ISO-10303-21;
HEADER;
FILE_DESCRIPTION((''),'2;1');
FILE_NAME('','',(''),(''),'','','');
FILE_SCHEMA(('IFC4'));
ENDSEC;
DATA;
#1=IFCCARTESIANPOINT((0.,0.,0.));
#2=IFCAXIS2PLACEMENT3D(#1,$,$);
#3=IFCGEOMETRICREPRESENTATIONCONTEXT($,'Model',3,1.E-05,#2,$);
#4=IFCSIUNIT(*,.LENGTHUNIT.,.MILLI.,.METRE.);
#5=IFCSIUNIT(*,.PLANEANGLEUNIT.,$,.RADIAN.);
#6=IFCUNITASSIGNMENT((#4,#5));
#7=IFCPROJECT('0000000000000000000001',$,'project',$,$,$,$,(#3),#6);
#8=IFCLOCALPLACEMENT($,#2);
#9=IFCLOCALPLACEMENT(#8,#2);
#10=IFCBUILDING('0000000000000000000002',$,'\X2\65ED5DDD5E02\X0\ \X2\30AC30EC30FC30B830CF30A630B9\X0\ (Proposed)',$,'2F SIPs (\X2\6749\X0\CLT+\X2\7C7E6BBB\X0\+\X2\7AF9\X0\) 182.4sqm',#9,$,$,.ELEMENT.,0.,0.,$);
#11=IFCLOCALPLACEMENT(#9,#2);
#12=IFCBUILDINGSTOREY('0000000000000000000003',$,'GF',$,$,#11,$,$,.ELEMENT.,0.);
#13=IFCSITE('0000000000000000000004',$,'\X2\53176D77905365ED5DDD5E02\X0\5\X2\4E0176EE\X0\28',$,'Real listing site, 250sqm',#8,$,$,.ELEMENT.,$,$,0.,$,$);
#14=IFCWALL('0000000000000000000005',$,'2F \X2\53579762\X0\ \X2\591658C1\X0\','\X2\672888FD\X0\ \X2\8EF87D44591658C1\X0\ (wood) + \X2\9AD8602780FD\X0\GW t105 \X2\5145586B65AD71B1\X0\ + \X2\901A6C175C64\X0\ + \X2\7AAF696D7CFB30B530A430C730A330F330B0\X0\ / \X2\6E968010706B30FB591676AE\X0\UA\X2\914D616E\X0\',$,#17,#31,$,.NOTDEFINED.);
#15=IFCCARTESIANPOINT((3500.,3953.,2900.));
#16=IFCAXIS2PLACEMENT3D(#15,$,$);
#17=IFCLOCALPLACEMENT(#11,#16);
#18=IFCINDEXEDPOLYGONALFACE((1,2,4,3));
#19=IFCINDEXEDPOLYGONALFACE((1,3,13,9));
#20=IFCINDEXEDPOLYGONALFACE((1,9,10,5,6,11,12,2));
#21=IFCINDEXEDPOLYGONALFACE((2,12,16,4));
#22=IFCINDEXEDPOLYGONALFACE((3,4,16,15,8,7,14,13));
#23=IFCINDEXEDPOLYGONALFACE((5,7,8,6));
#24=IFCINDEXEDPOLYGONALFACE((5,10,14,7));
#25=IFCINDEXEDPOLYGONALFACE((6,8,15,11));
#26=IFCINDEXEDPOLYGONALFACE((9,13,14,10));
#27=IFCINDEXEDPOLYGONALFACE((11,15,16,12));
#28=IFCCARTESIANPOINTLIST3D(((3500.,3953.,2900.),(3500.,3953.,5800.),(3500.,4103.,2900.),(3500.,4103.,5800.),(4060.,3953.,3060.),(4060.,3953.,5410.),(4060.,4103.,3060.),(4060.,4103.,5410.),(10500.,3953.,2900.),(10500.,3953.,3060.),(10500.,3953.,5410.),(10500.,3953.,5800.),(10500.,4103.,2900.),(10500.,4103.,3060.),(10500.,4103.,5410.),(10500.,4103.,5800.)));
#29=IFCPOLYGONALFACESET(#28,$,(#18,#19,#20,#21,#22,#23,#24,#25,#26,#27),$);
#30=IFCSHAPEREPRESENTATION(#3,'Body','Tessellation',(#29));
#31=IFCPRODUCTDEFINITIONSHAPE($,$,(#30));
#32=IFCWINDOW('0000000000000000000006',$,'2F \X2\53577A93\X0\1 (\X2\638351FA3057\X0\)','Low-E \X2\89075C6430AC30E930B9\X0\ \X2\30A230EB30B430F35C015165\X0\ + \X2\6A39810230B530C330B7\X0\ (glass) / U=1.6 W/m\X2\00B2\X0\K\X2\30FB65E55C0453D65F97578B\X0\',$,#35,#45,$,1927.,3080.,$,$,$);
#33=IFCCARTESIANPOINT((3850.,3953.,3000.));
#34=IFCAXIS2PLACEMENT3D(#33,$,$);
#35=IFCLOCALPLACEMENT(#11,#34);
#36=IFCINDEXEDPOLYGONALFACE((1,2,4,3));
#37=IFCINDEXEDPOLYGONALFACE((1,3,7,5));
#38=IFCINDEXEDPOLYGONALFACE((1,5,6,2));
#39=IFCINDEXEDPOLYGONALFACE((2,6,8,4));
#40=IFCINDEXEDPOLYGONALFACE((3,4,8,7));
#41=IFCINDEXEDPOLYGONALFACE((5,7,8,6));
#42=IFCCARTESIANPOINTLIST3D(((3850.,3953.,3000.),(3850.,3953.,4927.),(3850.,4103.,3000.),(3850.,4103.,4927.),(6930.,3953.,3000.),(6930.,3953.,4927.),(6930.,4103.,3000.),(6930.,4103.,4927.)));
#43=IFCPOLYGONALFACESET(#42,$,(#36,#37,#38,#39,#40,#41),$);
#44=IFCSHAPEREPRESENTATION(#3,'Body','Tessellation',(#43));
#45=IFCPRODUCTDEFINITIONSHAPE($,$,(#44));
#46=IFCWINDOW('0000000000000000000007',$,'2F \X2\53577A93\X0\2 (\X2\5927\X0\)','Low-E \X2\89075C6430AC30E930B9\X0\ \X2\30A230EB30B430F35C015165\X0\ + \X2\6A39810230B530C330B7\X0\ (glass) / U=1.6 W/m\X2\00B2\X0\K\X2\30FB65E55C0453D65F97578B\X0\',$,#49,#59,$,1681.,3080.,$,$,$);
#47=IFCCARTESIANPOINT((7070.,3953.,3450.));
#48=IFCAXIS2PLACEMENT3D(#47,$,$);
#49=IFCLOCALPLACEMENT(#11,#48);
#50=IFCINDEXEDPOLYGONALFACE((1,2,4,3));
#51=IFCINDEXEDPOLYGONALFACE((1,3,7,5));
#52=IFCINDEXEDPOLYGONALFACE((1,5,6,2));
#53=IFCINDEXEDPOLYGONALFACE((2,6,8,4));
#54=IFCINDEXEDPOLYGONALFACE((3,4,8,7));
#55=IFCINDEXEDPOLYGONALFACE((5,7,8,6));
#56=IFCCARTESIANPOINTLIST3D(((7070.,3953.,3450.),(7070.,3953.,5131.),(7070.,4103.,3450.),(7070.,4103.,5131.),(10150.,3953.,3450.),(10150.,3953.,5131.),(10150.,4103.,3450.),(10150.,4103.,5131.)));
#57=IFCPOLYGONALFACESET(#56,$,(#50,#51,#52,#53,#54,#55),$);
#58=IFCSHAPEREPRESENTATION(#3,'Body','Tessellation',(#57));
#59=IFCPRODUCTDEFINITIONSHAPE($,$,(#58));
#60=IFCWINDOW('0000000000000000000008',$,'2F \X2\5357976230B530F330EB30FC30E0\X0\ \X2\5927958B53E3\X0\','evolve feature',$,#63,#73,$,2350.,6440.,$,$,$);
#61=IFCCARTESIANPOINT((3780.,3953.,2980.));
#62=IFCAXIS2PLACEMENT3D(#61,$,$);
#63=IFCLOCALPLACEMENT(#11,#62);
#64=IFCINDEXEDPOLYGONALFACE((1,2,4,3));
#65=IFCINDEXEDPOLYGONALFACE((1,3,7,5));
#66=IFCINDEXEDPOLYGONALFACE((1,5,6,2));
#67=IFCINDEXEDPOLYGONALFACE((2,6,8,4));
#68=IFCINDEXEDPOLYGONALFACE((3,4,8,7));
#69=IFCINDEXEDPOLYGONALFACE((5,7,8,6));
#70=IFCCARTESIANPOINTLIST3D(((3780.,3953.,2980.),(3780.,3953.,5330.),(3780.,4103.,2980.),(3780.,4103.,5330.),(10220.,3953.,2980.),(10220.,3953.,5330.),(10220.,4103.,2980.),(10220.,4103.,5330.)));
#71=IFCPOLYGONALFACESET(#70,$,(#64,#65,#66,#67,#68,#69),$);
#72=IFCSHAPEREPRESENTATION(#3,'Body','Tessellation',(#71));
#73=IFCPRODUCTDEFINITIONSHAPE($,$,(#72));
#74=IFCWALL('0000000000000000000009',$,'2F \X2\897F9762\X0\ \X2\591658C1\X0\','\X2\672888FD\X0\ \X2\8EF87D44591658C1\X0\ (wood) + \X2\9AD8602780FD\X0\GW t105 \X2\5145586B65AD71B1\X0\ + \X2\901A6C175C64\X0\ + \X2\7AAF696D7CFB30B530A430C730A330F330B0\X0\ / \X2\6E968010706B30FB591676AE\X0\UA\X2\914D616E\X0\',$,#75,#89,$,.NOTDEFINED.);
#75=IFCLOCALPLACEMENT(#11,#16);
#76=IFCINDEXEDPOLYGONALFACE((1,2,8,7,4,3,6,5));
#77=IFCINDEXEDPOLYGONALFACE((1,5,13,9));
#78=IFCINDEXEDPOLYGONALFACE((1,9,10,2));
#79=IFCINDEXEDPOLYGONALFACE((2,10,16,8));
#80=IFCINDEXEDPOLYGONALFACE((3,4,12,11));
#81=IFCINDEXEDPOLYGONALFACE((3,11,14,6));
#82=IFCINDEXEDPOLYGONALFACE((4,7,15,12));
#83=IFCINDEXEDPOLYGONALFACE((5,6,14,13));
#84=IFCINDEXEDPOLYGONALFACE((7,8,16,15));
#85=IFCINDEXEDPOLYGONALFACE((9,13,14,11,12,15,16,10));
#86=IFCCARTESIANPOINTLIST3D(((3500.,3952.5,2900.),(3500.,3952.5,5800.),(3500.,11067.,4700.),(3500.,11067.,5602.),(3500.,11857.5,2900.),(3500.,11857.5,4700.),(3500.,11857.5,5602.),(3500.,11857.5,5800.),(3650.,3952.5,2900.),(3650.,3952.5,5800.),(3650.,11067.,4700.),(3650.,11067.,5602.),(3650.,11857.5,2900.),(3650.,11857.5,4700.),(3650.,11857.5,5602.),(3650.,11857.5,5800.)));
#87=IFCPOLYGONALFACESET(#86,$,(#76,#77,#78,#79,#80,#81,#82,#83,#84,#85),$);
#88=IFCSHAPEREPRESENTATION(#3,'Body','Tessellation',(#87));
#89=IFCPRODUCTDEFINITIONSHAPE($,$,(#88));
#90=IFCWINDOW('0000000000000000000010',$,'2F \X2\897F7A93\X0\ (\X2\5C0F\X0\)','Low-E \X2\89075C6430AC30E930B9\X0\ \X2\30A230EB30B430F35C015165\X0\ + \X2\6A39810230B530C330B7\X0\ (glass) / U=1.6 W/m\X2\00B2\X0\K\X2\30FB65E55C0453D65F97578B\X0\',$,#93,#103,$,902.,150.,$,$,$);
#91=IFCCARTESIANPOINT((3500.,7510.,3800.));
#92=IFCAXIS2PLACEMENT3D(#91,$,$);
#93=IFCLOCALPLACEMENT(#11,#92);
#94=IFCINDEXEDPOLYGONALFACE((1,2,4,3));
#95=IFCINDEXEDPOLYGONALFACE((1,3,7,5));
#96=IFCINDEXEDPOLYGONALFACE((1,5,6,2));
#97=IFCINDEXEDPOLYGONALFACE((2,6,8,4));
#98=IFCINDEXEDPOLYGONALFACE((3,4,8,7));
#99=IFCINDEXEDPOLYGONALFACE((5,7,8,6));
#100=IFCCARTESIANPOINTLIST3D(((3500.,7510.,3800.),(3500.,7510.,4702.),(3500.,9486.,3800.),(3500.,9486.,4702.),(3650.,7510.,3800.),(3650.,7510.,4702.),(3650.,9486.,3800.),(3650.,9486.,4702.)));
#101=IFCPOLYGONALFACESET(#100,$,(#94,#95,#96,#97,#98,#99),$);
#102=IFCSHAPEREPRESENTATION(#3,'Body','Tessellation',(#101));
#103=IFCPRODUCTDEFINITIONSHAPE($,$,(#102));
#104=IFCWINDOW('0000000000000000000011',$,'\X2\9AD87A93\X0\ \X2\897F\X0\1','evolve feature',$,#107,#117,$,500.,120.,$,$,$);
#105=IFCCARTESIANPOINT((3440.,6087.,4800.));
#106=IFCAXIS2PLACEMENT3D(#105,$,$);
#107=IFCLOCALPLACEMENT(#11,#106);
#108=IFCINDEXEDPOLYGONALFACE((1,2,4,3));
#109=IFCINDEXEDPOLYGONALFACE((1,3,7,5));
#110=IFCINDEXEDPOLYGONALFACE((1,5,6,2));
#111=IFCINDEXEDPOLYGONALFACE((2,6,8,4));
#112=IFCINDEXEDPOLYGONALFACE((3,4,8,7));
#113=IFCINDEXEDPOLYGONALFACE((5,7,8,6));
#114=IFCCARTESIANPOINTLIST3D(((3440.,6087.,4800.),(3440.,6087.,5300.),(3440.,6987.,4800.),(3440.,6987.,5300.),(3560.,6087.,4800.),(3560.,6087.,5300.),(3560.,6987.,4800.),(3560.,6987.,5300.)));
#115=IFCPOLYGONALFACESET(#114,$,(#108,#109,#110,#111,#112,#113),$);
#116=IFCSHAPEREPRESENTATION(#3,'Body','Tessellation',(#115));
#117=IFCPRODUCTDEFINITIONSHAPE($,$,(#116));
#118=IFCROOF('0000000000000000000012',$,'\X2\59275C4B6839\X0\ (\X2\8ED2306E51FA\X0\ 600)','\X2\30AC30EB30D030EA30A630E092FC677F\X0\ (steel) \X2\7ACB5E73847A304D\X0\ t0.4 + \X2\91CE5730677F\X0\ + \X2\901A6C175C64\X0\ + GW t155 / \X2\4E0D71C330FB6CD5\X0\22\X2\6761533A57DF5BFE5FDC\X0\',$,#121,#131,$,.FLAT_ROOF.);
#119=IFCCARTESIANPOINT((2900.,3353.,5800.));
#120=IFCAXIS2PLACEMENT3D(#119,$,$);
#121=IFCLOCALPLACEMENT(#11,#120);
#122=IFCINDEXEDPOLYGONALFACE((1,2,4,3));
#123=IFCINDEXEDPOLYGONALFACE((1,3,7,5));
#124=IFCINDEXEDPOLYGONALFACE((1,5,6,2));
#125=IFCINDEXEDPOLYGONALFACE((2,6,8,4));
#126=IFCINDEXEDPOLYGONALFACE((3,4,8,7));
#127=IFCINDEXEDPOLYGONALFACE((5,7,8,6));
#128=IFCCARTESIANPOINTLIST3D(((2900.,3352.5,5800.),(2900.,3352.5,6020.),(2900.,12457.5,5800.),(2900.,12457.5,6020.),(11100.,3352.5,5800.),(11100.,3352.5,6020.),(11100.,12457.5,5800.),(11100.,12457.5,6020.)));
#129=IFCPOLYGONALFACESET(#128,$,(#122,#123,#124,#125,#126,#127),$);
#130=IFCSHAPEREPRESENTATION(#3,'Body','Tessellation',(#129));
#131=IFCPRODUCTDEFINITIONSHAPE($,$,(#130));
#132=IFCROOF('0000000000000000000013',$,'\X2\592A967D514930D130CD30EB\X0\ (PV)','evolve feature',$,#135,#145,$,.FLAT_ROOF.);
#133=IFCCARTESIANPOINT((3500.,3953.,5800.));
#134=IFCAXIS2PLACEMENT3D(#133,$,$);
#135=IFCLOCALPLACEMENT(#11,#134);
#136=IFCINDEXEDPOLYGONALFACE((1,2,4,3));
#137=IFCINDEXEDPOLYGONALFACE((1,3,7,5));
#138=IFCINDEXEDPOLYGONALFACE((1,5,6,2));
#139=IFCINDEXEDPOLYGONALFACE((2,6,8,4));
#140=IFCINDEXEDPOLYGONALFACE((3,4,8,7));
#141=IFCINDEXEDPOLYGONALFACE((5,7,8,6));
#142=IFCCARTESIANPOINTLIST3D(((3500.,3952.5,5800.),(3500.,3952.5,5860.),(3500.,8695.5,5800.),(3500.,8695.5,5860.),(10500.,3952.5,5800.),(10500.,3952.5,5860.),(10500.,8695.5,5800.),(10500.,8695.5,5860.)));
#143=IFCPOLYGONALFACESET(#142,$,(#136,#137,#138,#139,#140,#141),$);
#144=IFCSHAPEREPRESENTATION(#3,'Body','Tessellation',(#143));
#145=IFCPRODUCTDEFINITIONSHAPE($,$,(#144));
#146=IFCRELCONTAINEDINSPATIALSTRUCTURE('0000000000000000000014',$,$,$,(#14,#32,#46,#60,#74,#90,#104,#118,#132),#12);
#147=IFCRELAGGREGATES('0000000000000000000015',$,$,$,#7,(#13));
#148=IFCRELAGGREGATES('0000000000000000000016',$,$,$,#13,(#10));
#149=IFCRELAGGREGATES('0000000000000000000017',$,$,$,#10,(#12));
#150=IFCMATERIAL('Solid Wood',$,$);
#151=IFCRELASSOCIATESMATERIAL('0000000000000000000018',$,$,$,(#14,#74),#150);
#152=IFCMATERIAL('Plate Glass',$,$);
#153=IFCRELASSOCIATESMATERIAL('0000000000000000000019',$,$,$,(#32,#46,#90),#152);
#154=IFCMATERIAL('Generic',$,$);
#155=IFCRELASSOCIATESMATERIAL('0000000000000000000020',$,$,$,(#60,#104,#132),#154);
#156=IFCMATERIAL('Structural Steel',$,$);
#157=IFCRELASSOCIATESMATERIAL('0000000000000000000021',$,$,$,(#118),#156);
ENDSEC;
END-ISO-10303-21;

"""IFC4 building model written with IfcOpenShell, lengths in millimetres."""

from ifc_helpers import new_model, si_unit, frame, frame_2d, origin, place, context, project, spatial, rectangle, extrude, material, element, fill, save


model = new_model("IFC4")

# Units and contexts
model_context = context("Model", 3, precision=1e-05, world=origin())
ifc_project = project(units=[si_unit("LENGTHUNIT", "METRE", prefix="MILLI"), si_unit("PLANEANGLEUNIT", "RADIAN")], contexts=[model_context])

# Site, building, storey
site_placement = place(None, origin())
site = spatial("IfcSite", under=ifc_project, at=site_placement, Name="北海道旭川市5丁目28", ObjectType="Real listing site, 250sqm", CompositionType="ELEMENT", RefElevation=0.0)
building_placement = place(site_placement, origin())
building = spatial("IfcBuilding", under=site, at=building_placement, Name="旭川市 ガレージハウス (Proposed)", ObjectType="2F SIPs (杉CLT+籾殻+竹) 182.4sqm", CompositionType="ELEMENT", ElevationOfRefHeight=0.0, ElevationOfTerrain=0.0)
storey_placement = place(building_placement, origin())
storey = spatial("IfcBuildingStorey", under=building, at=storey_placement, Name="GF", CompositionType="ELEMENT", Elevation=0.0)

# Shared definitions
ifc_material_1 = material(Name="Solid Wood")
ifc_material_2 = material(Name="Generic")

# Shared definitions
ifc_material_3 = material(Name="Plate Glass")

# Walls, openings, windows
wall_1_placement = place(storey_placement, frame((3500.0, 3953.0, 2900.0)))
wall_1 = element("IfcWall", 1, at=wall_1_placement, inside=storey, material=ifc_material_1, Name="2F 南面 外壁", Description="木製 軸組外壁 (wood) + 高性能GW t105 充填断熱 + 通気層 + 窯業系サイディング / 準耐火・外皮UA配慮", PredefinedType="NOTDEFINED", context=model_context, shape_type="SweptSolid", body=[
    extrude(rectangle(XDim=7000.0, YDim=150.0, at=frame_2d((3500.0, 75.0))), frame((3500.0, 3953.0, 2900.0)), (0.0, 0.0, 1.0), 2900.0),
])
opening_1_placement = place(storey_placement, frame((3850.0, 3953.0, 3000.0)))
opening_1 = element("IfcOpeningElement", 2, at=opening_1_placement, cuts=wall_1, PredefinedType="NOTDEFINED", context=model_context, shape_type="SweptSolid", body=[
    extrude(rectangle(XDim=3080.0, YDim=150.0, at=frame_2d((1540.0, 75.0))), frame((3850.0, 3953.0, 3000.0)), (0.0, 0.0, 1.0), 1927.0),
])
opening_2_placement = place(storey_placement, frame((7070.0, 3953.0, 3450.0)))
opening_2 = element("IfcOpeningElement", 3, at=opening_2_placement, cuts=wall_1, PredefinedType="NOTDEFINED", context=model_context, shape_type="SweptSolid", body=[
    extrude(rectangle(XDim=3080.0, YDim=150.0, at=frame_2d((1540.0, 75.0))), frame((7070.0, 3953.0, 3450.0)), (0.0, 0.0, 1.0), 1681.0),
])
opening_3_placement = place(storey_placement, frame((3780.0, 3953.0, 2980.0)))
opening_3 = element("IfcOpeningElement", 4, at=opening_3_placement, cuts=wall_1, PredefinedType="NOTDEFINED", context=model_context, shape_type="SweptSolid", body=[
    extrude(rectangle(XDim=6440.0, YDim=150.0, at=frame_2d((3220.0, 75.0))), frame((3780.0, 3953.0, 2980.0)), (0.0, 0.0, 1.0), 2350.0),
])
window_1_placement = place(storey_placement, frame((3850.0, 3953.0, 3000.0)))
window_1 = element("IfcWindow", 5, at=window_1_placement, inside=storey, material=ifc_material_3, Name="2F 南窓1 (掃出し)", Description="Low-E 複層ガラス アルゴン封入 + 樹脂サッシ (glass) / U=1.6 W/m²K・日射取得型", OverallHeight=1927.0, OverallWidth=3080.0, context=model_context, shape_type="SweptSolid", body=[
    extrude(rectangle(XDim=3080.0, YDim=150.0, at=frame_2d((1540.0, 75.0))), frame((3850.0, 3953.0, 3000.0)), (0.0, 0.0, 1.0), 1927.0),
])
fill(opening_1, window_1)
window_2_placement = place(storey_placement, frame((7070.0, 3953.0, 3450.0)))
window_2 = element("IfcWindow", 6, at=window_2_placement, inside=storey, material=ifc_material_3, Name="2F 南窓2 (大)", Description="Low-E 複層ガラス アルゴン封入 + 樹脂サッシ (glass) / U=1.6 W/m²K・日射取得型", OverallHeight=1681.0, OverallWidth=3080.0, context=model_context, shape_type="SweptSolid", body=[
    extrude(rectangle(XDim=3080.0, YDim=150.0, at=frame_2d((1540.0, 75.0))), frame((7070.0, 3953.0, 3450.0)), (0.0, 0.0, 1.0), 1681.0),
])
fill(opening_2, window_2)
window_3_placement = place(storey_placement, frame((3780.0, 3953.0, 2980.0)))
window_3 = element("IfcWindow", 7, at=window_3_placement, inside=storey, material=ifc_material_2, Name="2F 南面サンルーム 大開口", Description="evolve feature", OverallHeight=2350.0, OverallWidth=6440.0, context=model_context, shape_type="SweptSolid", body=[
    extrude(rectangle(XDim=6440.0, YDim=150.0, at=frame_2d((3220.0, 75.0))), frame((3780.0, 3953.0, 2980.0)), (0.0, 0.0, 1.0), 2350.0),
])
fill(opening_3, window_3)
wall_2_placement = place(storey_placement, frame((3500.0, 3953.0, 2900.0)))
wall_2 = element("IfcWall", 8, at=wall_2_placement, inside=storey, material=ifc_material_1, Name="2F 西面 外壁", Description="木製 軸組外壁 (wood) + 高性能GW t105 充填断熱 + 通気層 + 窯業系サイディング / 準耐火・外皮UA配慮", PredefinedType="NOTDEFINED", context=model_context, shape_type="SweptSolid", body=[
    extrude(rectangle(XDim=150.0, YDim=7905.0, at=frame_2d((75.0, 3952.0))), frame((3500.0, 3953.0, 2900.0)), (0.0, 0.0, 1.0), 2900.0),
])
opening_4_placement = place(storey_placement, frame((3500.0, 7510.0, 3800.0)))
opening_4 = element("IfcOpeningElement", 9, at=opening_4_placement, cuts=wall_2, PredefinedType="NOTDEFINED", context=model_context, shape_type="SweptSolid", body=[
    extrude(rectangle(XDim=150.0, YDim=1976.0, at=frame_2d((75.0, 988.0))), frame((3500.0, 7510.0, 3800.0)), (0.0, 0.0, 1.0), 902.0),
])
opening_5_placement = place(storey_placement, frame((3440.0, 6087.0, 4800.0)))
opening_5 = element("IfcOpeningElement", 10, at=opening_5_placement, cuts=wall_2, PredefinedType="NOTDEFINED", context=model_context, shape_type="SweptSolid", body=[
    extrude(rectangle(XDim=120.0, YDim=900.0, at=frame_2d((60.0, 450.0))), frame((3440.0, 6087.0, 4800.0)), (0.0, 0.0, 1.0), 500.0),
])
window_4_placement = place(storey_placement, frame((3500.0, 7510.0, 3800.0)))
window_4 = element("IfcWindow", 11, at=window_4_placement, inside=storey, material=ifc_material_3, Name="2F 西窓 (小)", Description="Low-E 複層ガラス アルゴン封入 + 樹脂サッシ (glass) / U=1.6 W/m²K・日射取得型", OverallHeight=902.0, OverallWidth=150.0, context=model_context, shape_type="SweptSolid", body=[
    extrude(rectangle(XDim=150.0, YDim=1976.0, at=frame_2d((75.0, 988.0))), frame((3500.0, 7510.0, 3800.0)), (0.0, 0.0, 1.0), 902.0),
])
fill(opening_4, window_4)
window_5_placement = place(storey_placement, frame((3440.0, 6087.0, 4800.0)))
window_5 = element("IfcWindow", 12, at=window_5_placement, inside=storey, material=ifc_material_2, Name="高窓 西1", Description="evolve feature", OverallHeight=500.0, OverallWidth=120.0, context=model_context, shape_type="SweptSolid", body=[
    extrude(rectangle(XDim=120.0, YDim=900.0, at=frame_2d((60.0, 450.0))), frame((3440.0, 6087.0, 4800.0)), (0.0, 0.0, 1.0), 500.0),
])
fill(opening_5, window_5)

# Roofs
ifc_material_4 = material(Name="Structural Steel")
roof_1_placement = place(storey_placement, frame((2900.0, 3353.0, 5800.0)))
element("IfcRoof", 13, at=roof_1_placement, inside=storey, material=ifc_material_4, Name="大屋根 (軒の出 600)", Description="ガルバリウム鋼板 (steel) 立平葺き t0.4 + 野地板 + 通気層 + GW t155 / 不燃・法22条区域対応", PredefinedType="FLAT_ROOF", context=model_context, shape_type="SweptSolid", body=[
    extrude(rectangle(XDim=8200.0, YDim=9105.0, at=frame_2d((4100.0, 4552.0))), frame((2900.0, 3353.0, 5800.0)), (0.0, 0.0, 1.0), 220.0),
])
roof_2_placement = place(storey_placement, frame((3500.0, 3953.0, 5800.0)))
element("IfcRoof", 14, at=roof_2_placement, inside=storey, material=ifc_material_2, Name="太陽光パネル (PV)", Description="evolve feature", PredefinedType="FLAT_ROOF", context=model_context, shape_type="SweptSolid", body=[
    extrude(rectangle(XDim=7000.0, YDim=4743.0, at=frame_2d((3500.0, 2371.0))), frame((3500.0, 3953.0, 5800.0)), (0.0, 0.0, 1.0), 60.0),
])

save(model, "model.ifc")
